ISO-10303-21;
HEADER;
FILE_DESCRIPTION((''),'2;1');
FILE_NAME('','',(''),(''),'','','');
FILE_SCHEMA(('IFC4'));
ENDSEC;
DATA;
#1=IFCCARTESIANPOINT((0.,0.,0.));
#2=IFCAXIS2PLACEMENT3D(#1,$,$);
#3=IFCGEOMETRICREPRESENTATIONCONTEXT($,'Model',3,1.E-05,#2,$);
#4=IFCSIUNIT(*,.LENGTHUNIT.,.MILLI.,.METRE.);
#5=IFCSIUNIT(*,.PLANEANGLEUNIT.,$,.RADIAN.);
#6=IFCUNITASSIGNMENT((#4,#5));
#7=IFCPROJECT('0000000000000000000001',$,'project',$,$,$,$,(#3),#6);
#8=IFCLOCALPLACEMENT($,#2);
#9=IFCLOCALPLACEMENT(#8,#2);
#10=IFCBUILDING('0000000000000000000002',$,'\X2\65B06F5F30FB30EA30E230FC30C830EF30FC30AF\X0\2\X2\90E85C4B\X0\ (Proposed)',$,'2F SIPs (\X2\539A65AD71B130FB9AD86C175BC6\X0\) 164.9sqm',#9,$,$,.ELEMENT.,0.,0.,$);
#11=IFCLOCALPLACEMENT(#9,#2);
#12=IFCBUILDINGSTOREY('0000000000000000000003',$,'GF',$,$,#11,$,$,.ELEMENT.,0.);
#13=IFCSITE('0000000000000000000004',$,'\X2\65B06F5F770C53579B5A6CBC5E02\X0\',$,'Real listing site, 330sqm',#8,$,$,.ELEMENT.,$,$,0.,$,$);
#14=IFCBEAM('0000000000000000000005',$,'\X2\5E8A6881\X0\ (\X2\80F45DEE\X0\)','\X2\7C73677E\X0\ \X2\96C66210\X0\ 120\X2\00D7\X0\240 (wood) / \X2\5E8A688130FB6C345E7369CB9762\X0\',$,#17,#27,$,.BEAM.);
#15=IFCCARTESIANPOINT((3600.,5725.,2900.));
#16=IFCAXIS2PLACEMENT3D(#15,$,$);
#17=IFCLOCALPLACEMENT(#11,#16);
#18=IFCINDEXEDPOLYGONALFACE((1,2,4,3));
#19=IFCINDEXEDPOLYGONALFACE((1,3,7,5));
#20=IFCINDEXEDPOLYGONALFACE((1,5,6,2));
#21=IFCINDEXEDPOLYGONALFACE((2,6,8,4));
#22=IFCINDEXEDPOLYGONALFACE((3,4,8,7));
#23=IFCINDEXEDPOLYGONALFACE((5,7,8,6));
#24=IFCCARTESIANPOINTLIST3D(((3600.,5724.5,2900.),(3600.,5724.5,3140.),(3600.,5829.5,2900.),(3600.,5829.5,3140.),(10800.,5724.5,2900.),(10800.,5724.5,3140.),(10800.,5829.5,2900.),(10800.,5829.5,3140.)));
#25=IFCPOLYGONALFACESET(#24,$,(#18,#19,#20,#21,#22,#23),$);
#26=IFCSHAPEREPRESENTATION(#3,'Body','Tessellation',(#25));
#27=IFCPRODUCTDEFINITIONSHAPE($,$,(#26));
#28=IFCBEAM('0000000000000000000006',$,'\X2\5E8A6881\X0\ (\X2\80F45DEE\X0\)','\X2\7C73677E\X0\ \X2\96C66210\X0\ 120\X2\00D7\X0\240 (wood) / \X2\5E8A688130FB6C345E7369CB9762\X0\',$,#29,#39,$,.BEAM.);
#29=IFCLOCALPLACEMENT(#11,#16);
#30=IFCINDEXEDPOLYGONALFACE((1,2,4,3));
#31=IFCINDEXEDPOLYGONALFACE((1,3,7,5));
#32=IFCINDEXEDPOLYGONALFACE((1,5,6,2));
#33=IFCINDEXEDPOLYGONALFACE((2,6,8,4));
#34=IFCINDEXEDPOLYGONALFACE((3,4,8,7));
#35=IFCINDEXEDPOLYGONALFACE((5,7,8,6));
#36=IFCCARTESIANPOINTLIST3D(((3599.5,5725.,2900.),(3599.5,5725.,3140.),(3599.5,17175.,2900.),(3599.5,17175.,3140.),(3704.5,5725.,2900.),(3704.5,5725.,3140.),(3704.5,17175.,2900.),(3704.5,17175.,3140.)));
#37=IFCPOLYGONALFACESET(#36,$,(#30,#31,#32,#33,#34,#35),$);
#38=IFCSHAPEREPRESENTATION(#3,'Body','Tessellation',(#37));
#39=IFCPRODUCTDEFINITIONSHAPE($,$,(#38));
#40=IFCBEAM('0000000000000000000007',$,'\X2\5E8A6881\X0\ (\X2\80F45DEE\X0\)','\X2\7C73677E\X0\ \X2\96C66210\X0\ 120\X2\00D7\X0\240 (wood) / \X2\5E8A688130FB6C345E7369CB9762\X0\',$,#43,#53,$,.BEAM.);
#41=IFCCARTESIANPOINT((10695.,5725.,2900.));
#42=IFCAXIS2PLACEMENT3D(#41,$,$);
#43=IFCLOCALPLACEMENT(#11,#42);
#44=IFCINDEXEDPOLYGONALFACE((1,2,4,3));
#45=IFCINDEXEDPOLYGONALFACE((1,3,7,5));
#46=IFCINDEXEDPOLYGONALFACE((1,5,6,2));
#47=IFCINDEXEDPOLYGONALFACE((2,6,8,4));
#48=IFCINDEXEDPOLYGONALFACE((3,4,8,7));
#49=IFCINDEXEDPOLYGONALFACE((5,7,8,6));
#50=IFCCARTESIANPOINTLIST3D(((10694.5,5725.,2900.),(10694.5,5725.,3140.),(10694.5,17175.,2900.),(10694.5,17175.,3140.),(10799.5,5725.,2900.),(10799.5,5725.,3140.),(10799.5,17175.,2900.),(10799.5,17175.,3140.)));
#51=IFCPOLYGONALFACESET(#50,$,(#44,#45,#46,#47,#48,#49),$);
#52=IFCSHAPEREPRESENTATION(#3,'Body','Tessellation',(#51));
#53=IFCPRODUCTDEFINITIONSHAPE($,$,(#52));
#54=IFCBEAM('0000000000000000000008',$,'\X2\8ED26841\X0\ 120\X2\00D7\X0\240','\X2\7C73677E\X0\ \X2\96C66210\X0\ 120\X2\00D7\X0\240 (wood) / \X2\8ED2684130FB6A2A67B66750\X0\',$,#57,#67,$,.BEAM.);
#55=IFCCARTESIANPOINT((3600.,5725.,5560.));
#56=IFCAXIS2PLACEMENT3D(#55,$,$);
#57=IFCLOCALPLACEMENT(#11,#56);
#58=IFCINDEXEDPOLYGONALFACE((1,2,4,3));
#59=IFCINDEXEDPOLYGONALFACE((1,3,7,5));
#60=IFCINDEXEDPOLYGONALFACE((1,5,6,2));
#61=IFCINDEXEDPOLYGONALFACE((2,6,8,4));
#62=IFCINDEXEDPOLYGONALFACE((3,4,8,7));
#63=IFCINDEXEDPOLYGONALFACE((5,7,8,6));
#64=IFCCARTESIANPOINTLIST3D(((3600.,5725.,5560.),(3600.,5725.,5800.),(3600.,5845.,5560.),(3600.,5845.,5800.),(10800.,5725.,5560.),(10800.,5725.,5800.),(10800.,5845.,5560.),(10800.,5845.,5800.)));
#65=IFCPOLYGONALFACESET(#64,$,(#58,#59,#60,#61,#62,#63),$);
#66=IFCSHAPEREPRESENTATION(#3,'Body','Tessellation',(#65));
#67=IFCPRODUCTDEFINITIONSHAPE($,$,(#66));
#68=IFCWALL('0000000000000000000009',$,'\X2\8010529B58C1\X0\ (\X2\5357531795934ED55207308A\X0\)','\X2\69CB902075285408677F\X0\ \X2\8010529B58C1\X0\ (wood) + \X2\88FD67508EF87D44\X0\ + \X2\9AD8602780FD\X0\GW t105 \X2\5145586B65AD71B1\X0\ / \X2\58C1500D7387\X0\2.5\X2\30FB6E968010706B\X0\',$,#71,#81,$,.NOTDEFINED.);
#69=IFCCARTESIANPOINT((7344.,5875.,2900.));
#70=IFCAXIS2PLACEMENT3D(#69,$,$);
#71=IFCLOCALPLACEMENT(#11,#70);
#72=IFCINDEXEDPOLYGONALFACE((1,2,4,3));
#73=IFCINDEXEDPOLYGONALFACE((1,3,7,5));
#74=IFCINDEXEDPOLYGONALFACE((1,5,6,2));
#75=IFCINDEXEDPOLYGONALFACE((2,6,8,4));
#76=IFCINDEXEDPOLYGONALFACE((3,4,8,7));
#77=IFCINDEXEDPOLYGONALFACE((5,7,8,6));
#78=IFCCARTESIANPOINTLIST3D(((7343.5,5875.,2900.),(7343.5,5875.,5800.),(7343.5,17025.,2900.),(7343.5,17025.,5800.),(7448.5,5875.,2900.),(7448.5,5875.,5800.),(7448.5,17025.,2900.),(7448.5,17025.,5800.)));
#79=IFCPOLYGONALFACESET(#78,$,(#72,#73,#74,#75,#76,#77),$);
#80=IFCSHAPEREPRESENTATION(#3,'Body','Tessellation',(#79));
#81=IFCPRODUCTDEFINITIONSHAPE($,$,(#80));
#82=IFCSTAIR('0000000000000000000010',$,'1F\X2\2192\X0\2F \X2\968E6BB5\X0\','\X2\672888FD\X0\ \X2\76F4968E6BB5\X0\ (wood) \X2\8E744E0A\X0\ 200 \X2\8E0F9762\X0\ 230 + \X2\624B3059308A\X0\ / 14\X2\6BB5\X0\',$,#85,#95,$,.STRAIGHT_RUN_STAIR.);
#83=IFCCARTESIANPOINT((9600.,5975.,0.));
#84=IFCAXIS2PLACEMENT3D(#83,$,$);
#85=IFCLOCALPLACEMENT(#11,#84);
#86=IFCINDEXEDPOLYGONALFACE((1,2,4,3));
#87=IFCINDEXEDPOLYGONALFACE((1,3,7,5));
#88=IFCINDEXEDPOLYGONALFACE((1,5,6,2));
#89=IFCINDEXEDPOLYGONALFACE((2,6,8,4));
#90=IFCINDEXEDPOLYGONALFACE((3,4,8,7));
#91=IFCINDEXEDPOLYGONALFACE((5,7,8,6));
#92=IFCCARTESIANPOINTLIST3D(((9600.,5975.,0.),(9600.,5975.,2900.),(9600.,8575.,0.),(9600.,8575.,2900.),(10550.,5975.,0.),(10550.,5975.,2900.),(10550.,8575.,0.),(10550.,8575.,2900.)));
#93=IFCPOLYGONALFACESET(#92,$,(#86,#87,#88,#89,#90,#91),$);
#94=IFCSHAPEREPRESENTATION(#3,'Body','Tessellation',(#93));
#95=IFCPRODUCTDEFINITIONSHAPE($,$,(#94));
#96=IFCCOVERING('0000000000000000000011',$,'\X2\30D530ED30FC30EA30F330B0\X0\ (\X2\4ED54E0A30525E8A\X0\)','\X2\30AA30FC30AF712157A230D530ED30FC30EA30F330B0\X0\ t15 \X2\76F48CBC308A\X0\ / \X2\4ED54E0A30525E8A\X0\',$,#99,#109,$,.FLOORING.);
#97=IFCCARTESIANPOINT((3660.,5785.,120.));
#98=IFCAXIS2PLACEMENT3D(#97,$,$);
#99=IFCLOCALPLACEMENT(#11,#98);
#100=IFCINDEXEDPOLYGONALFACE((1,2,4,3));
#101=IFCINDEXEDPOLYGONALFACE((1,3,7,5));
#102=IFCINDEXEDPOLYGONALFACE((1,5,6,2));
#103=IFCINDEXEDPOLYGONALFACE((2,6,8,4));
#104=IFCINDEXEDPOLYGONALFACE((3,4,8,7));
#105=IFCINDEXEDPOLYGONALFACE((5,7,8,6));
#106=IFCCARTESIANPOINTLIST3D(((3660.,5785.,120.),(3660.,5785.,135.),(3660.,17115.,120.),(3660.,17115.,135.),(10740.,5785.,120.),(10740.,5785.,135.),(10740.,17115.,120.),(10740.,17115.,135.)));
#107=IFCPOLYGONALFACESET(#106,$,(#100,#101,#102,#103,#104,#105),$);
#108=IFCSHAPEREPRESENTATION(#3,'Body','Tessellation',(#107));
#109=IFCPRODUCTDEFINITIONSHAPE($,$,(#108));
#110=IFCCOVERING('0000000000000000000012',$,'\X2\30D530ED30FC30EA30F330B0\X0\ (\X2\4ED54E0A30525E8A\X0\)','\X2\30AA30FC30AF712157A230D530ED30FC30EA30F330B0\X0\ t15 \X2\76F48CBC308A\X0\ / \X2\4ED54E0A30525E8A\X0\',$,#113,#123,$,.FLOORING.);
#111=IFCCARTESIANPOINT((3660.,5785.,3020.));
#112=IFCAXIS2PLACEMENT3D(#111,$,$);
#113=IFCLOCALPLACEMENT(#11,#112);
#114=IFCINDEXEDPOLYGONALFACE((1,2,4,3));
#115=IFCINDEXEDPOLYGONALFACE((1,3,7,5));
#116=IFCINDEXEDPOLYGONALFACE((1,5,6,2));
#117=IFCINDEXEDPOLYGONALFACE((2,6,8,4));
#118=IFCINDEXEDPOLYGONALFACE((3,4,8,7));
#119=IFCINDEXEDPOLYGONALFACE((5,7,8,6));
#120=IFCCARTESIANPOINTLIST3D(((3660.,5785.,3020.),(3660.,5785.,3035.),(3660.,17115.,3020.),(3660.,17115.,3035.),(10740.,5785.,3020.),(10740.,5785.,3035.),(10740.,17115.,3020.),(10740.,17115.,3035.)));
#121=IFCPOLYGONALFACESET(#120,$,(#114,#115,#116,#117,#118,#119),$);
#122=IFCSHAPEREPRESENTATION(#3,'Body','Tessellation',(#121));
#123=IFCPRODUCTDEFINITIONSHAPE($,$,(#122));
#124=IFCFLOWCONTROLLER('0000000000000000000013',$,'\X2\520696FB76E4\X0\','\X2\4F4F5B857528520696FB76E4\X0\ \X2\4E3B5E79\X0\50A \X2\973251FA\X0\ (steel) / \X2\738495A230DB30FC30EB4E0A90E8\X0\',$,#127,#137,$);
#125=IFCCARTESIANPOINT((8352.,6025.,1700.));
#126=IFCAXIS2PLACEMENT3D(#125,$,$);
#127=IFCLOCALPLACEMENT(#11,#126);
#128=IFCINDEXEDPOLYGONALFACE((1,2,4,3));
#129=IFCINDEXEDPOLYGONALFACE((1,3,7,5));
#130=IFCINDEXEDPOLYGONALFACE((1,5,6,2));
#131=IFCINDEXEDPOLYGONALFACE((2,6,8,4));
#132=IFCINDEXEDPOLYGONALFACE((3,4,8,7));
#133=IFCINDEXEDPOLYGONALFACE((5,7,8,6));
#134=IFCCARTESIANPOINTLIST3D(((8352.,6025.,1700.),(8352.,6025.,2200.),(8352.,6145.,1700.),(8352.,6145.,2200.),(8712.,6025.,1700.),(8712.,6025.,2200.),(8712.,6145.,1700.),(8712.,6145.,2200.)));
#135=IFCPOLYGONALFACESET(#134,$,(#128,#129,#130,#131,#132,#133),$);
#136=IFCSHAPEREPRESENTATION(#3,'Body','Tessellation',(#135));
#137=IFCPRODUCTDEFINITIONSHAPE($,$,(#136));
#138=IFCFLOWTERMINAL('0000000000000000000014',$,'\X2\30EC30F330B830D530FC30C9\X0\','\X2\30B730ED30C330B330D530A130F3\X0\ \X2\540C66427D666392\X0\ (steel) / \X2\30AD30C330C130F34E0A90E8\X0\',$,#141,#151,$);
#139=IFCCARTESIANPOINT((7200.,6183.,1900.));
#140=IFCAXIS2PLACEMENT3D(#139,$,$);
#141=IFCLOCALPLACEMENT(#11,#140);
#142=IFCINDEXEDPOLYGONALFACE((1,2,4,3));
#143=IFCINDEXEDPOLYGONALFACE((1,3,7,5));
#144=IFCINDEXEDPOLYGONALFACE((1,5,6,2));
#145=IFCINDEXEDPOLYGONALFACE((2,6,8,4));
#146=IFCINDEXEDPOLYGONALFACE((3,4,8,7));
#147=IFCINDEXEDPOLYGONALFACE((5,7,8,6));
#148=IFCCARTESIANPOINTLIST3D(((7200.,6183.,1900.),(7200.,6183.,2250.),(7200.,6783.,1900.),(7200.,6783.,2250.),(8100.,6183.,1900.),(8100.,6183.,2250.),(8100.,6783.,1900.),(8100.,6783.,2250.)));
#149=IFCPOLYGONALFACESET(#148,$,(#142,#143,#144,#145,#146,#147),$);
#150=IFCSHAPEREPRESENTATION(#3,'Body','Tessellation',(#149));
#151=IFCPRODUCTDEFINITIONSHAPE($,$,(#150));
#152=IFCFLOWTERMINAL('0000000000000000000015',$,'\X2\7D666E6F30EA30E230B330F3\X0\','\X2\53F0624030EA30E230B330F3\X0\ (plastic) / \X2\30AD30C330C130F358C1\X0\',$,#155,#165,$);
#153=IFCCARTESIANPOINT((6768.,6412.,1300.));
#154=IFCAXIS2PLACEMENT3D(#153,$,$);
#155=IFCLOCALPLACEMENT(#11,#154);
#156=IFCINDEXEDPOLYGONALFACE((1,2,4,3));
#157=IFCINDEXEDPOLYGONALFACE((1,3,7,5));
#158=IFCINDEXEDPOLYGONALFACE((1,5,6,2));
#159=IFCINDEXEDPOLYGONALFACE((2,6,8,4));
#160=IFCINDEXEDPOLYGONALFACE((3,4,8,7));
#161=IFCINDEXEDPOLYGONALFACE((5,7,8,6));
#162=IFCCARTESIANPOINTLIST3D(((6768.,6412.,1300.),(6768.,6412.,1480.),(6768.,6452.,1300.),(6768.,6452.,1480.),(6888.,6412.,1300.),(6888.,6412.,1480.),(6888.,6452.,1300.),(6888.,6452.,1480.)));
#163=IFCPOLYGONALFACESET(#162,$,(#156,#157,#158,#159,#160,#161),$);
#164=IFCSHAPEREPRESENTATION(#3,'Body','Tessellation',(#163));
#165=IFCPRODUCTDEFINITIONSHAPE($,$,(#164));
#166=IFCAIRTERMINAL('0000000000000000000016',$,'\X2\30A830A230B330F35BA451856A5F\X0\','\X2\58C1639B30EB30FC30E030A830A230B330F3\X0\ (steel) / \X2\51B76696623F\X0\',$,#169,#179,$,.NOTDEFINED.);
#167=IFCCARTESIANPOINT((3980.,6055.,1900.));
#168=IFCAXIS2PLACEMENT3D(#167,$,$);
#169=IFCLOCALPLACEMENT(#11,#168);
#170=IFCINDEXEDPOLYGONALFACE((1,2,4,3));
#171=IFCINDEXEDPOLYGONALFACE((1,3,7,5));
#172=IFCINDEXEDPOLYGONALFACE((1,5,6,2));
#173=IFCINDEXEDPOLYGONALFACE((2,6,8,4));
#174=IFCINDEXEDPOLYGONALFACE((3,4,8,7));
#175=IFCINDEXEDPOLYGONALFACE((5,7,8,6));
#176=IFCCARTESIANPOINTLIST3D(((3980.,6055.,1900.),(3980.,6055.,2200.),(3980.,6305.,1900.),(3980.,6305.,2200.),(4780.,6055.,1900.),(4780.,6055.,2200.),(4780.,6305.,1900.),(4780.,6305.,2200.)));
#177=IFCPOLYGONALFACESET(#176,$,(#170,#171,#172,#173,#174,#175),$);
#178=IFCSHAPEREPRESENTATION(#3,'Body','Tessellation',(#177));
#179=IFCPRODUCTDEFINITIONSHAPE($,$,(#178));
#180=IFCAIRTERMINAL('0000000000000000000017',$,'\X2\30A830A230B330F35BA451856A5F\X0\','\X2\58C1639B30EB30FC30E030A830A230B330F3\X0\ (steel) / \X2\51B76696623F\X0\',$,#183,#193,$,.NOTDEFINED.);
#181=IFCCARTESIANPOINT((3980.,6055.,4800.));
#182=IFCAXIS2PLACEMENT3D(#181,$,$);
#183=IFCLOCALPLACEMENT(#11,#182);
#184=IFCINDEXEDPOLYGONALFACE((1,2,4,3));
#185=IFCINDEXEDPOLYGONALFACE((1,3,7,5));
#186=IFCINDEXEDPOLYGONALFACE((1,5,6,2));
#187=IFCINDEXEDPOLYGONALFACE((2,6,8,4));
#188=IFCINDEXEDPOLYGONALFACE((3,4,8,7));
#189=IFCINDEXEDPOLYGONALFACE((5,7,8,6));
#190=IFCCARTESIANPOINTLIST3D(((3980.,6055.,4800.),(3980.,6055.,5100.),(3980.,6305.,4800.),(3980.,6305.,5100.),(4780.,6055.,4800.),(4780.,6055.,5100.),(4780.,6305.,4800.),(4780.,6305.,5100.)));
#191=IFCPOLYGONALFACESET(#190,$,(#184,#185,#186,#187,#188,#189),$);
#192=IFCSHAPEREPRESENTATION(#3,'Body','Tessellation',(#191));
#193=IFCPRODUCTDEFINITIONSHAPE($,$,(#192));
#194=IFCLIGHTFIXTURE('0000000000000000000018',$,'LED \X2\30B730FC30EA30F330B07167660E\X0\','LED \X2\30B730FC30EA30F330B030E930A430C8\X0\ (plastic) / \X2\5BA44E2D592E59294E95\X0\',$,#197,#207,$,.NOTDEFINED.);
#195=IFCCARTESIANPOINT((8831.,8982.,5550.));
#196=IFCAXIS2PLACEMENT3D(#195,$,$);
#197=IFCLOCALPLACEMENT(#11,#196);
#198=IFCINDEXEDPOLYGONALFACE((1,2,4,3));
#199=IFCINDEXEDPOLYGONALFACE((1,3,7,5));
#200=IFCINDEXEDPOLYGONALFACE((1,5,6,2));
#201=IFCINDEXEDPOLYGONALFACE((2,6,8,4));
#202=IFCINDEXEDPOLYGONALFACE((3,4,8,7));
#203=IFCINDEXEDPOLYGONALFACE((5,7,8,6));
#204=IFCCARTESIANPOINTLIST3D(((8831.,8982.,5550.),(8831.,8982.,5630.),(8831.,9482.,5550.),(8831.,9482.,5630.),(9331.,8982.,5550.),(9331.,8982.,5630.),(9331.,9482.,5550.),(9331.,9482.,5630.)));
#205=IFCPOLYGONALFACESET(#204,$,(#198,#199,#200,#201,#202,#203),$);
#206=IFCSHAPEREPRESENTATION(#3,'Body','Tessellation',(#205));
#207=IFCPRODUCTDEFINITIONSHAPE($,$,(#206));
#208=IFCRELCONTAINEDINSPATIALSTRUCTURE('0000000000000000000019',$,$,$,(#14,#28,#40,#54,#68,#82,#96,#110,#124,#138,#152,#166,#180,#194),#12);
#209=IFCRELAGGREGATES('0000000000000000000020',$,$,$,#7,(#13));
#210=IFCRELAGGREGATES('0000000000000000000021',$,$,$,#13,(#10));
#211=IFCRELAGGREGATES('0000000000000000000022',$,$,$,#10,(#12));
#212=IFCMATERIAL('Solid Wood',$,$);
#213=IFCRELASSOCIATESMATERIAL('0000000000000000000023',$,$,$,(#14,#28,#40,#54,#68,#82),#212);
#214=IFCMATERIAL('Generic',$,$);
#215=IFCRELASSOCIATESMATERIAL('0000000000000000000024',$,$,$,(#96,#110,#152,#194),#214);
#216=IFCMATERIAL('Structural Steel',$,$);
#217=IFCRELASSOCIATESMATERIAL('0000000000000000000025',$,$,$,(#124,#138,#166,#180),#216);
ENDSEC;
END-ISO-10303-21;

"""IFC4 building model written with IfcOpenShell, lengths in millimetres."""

from ifc_helpers import new_model, si_unit, frame, frame_2d, origin, place, context, project, spatial, rectangle, extrude, material, element, save


model = new_model("IFC4")

# Units and contexts
model_context = context("Model", 3, precision=1e-05, world=origin())
ifc_project = project(units=[si_unit("LENGTHUNIT", "METRE", prefix="MILLI"), si_unit("PLANEANGLEUNIT", "RADIAN")], contexts=[model_context])

# Site, building, storey
site_placement = place(None, origin())
site = spatial("IfcSite", under=ifc_project, at=site_placement, Name="新潟県南魚沼市", ObjectType="Real listing site, 330sqm", CompositionType="ELEMENT", RefElevation=0.0)
building_placement = place(site_placement, origin())
building = spatial("IfcBuilding", under=site, at=building_placement, Name="新潟・リモートワーク2部屋 (Proposed)", ObjectType="2F SIPs (厚断熱・高気密) 164.9sqm", CompositionType="ELEMENT", ElevationOfRefHeight=0.0, ElevationOfTerrain=0.0)
storey_placement = place(building_placement, origin())
storey = spatial("IfcBuildingStorey", under=building, at=storey_placement, Name="GF", CompositionType="ELEMENT", Elevation=0.0)

# Shared definitions
ifc_material_1 = material(Name="Solid Wood")

# Beams
beam_1_placement = place(storey_placement, frame((3600.0, 5725.0, 2900.0)))
element("IfcBeam", 1, at=beam_1_placement, inside=storey, material=ifc_material_1, Name="床梁 (胴差)", Description="米松 集成 120×240 (wood) / 床梁・水平構面", PredefinedType="BEAM", context=model_context, shape_type="SweptSolid", body=[
    extrude(rectangle(XDim=7200.0, YDim=105.0, at=frame_2d((3600.0, 52.0))), frame((3600.0, 5725.0, 2900.0)), (0.0, 0.0, 1.0), 240.0),
])
beam_2_placement = place(storey_placement, frame((3600.0, 5725.0, 2900.0)))
element("IfcBeam", 2, at=beam_2_placement, inside=storey, material=ifc_material_1, Name="床梁 (胴差)", Description="米松 集成 120×240 (wood) / 床梁・水平構面", PredefinedType="BEAM", context=model_context, shape_type="SweptSolid", body=[
    extrude(rectangle(XDim=105.0, YDim=11450.0, at=frame_2d((52.0, 5725.0))), frame((3600.0, 5725.0, 2900.0)), (0.0, 0.0, 1.0), 240.0),
])
beam_3_placement = place(storey_placement, frame((10695.0, 5725.0, 2900.0)))
element("IfcBeam", 3, at=beam_3_placement, inside=storey, material=ifc_material_1, Name="床梁 (胴差)", Description="米松 集成 120×240 (wood) / 床梁・水平構面", PredefinedType="BEAM", context=model_context, shape_type="SweptSolid", body=[
    extrude(rectangle(XDim=105.0, YDim=11450.0, at=frame_2d((52.0, 5725.0))), frame((10695.0, 5725.0, 2900.0)), (0.0, 0.0, 1.0), 240.0),
])
beam_4_placement = place(storey_placement, frame((3600.0, 5725.0, 5560.0)))
element("IfcBeam", 4, at=beam_4_placement, inside=storey, material=ifc_material_1, Name="軒桁 120×240", Description="米松 集成 120×240 (wood) / 軒桁・横架材", PredefinedType="BEAM", context=model_context, shape_type="SweptSolid", body=[
    extrude(rectangle(XDim=7200.0, YDim=120.0, at=frame_2d((3600.0, 60.0))), frame((3600.0, 5725.0, 5560.0)), (0.0, 0.0, 1.0), 240.0),
])

# Wall
wall_1_placement = place(storey_placement, frame((7344.0, 5875.0, 2900.0)))
element("IfcWall", 5, at=wall_1_placement, inside=storey, material=ifc_material_1, Name="耐力壁 (南北間仕切り)", Description="構造用合板 耐力壁 (wood) + 製材軸組 + 高性能GW t105 充填断熱 / 壁倍率2.5・準耐火", PredefinedType="NOTDEFINED", context=model_context, shape_type="SweptSolid", body=[
    extrude(rectangle(XDim=105.0, YDim=11150.0, at=frame_2d((52.0, 5575.0))), frame((7344.0, 5875.0, 2900.0)), (0.0, 0.0, 1.0), 2900.0),
])

# Stair
stair_placement = place(storey_placement, frame((9600.0, 5975.0, 0.0)))
element("IfcStair", 6, at=stair_placement, inside=storey, material=ifc_material_1, Name="1F→2F 階段", Description="木製 直階段 (wood) 蹴上 200 踏面 230 + 手すり / 14段", PredefinedType="STRAIGHT_RUN_STAIR", context=model_context, shape_type="SweptSolid", body=[
    extrude(rectangle(XDim=950.0, YDim=2600.0, at=frame_2d((475.0, 1300.0))), frame((9600.0, 5975.0, 0.0)), (0.0, 0.0, 1.0), 2900.0),
])

# Coverings
ifc_material_2 = material(Name="Generic")
covering_1_placement = place(storey_placement, frame((3660.0, 5785.0, 120.0)))
element("IfcCovering", 7, at=covering_1_placement, inside=storey, material=ifc_material_2, Name="フローリング (仕上げ床)", Description="オーク無垢フローリング t15 直貼り / 仕上げ床", PredefinedType="FLOORING", context=model_context, shape_type="SweptSolid", body=[
    extrude(rectangle(XDim=7080.0, YDim=11330.0, at=frame_2d((3540.0, 5665.0))), frame((3660.0, 5785.0, 120.0)), (0.0, 0.0, 1.0), 15.0),
])
covering_2_placement = place(storey_placement, frame((3660.0, 5785.0, 3020.0)))
element("IfcCovering", 8, at=covering_2_placement, inside=storey, material=ifc_material_2, Name="フローリング (仕上げ床)", Description="オーク無垢フローリング t15 直貼り / 仕上げ床", PredefinedType="FLOORING", context=model_context, shape_type="SweptSolid", body=[
    extrude(rectangle(XDim=7080.0, YDim=11330.0, at=frame_2d((3540.0, 5665.0))), frame((3660.0, 5785.0, 3020.0)), (0.0, 0.0, 1.0), 15.0),
])

# Flow controller
ifc_material_3 = material(Name="Structural Steel")
flow_controller_placement = place(storey_placement, frame((8352.0, 6025.0, 1700.0)))
element("IfcFlowController", 9, at=flow_controller_placement, inside=storey, material=ifc_material_3, Name="分電盤", Description="住宅用分電盤 主幹50A 露出 (steel) / 玄関ホール上部", context=model_context, shape_type="SweptSolid", body=[
    extrude(rectangle(XDim=360.0, YDim=120.0, at=frame_2d((180.0, 60.0))), frame((8352.0, 6025.0, 1700.0)), (0.0, 0.0, 1.0), 500.0),
])

# Flow terminals
flow_terminal_1_placement = place(storey_placement, frame((7200.0, 6183.0, 1900.0)))
element("IfcFlowTerminal", 10, at=flow_terminal_1_placement, inside=storey, material=ifc_material_3, Name="レンジフード", Description="シロッコファン 同時給排 (steel) / キッチン上部", context=model_context, shape_type="SweptSolid", body=[
    extrude(rectangle(XDim=900.0, YDim=600.0, at=frame_2d((450.0, 300.0))), frame((7200.0, 6183.0, 1900.0)), (0.0, 0.0, 1.0), 350.0),
])
flow_terminal_2_placement = place(storey_placement, frame((6768.0, 6412.0, 1300.0)))
element("IfcFlowTerminal", 11, at=flow_terminal_2_placement, inside=storey, material=ifc_material_2, Name="給湯リモコン", Description="台所リモコン (plastic) / キッチン壁", context=model_context, shape_type="SweptSolid", body=[
    extrude(rectangle(XDim=120.0, YDim=40.0, at=frame_2d((60.0, 20.0))), frame((6768.0, 6412.0, 1300.0)), (0.0, 0.0, 1.0), 180.0),
])

# Air terminals
air_terminal_1_placement = place(storey_placement, frame((3980.0, 6055.0, 1900.0)))
element("IfcAirTerminal", 12, at=air_terminal_1_placement, inside=storey, material=ifc_material_3, Name="エアコン室内機", Description="壁掛ルームエアコン (steel) / 冷暖房", PredefinedType="NOTDEFINED", context=model_context, shape_type="SweptSolid", body=[
    extrude(rectangle(XDim=800.0, YDim=250.0, at=frame_2d((400.0, 125.0))), frame((3980.0, 6055.0, 1900.0)), (0.0, 0.0, 1.0), 300.0),
])
air_terminal_2_placement = place(storey_placement, frame((3980.0, 6055.0, 4800.0)))
element("IfcAirTerminal", 13, at=air_terminal_2_placement, inside=storey, material=ifc_material_3, Name="エアコン室内機", Description="壁掛ルームエアコン (steel) / 冷暖房", PredefinedType="NOTDEFINED", context=model_context, shape_type="SweptSolid", body=[
    extrude(rectangle(XDim=800.0, YDim=250.0, at=frame_2d((400.0, 125.0))), frame((3980.0, 6055.0, 4800.0)), (0.0, 0.0, 1.0), 300.0),
])

# Light fixture
light_fixture_placement = place(storey_placement, frame((8831.0, 8982.0, 5550.0)))
element("IfcLightFixture", 14, at=light_fixture_placement, inside=storey, material=ifc_material_2, Name="LED シーリング照明", Description="LED シーリングライト (plastic) / 室中央天井", PredefinedType="NOTDEFINED", context=model_context, shape_type="SweptSolid", body=[
    extrude(rectangle(XDim=500.0, YDim=500.0, at=frame_2d((250.0, 250.0))), frame((8831.0, 8982.0, 5550.0)), (0.0, 0.0, 1.0), 80.0),
])

save(model, "model.ifc")
